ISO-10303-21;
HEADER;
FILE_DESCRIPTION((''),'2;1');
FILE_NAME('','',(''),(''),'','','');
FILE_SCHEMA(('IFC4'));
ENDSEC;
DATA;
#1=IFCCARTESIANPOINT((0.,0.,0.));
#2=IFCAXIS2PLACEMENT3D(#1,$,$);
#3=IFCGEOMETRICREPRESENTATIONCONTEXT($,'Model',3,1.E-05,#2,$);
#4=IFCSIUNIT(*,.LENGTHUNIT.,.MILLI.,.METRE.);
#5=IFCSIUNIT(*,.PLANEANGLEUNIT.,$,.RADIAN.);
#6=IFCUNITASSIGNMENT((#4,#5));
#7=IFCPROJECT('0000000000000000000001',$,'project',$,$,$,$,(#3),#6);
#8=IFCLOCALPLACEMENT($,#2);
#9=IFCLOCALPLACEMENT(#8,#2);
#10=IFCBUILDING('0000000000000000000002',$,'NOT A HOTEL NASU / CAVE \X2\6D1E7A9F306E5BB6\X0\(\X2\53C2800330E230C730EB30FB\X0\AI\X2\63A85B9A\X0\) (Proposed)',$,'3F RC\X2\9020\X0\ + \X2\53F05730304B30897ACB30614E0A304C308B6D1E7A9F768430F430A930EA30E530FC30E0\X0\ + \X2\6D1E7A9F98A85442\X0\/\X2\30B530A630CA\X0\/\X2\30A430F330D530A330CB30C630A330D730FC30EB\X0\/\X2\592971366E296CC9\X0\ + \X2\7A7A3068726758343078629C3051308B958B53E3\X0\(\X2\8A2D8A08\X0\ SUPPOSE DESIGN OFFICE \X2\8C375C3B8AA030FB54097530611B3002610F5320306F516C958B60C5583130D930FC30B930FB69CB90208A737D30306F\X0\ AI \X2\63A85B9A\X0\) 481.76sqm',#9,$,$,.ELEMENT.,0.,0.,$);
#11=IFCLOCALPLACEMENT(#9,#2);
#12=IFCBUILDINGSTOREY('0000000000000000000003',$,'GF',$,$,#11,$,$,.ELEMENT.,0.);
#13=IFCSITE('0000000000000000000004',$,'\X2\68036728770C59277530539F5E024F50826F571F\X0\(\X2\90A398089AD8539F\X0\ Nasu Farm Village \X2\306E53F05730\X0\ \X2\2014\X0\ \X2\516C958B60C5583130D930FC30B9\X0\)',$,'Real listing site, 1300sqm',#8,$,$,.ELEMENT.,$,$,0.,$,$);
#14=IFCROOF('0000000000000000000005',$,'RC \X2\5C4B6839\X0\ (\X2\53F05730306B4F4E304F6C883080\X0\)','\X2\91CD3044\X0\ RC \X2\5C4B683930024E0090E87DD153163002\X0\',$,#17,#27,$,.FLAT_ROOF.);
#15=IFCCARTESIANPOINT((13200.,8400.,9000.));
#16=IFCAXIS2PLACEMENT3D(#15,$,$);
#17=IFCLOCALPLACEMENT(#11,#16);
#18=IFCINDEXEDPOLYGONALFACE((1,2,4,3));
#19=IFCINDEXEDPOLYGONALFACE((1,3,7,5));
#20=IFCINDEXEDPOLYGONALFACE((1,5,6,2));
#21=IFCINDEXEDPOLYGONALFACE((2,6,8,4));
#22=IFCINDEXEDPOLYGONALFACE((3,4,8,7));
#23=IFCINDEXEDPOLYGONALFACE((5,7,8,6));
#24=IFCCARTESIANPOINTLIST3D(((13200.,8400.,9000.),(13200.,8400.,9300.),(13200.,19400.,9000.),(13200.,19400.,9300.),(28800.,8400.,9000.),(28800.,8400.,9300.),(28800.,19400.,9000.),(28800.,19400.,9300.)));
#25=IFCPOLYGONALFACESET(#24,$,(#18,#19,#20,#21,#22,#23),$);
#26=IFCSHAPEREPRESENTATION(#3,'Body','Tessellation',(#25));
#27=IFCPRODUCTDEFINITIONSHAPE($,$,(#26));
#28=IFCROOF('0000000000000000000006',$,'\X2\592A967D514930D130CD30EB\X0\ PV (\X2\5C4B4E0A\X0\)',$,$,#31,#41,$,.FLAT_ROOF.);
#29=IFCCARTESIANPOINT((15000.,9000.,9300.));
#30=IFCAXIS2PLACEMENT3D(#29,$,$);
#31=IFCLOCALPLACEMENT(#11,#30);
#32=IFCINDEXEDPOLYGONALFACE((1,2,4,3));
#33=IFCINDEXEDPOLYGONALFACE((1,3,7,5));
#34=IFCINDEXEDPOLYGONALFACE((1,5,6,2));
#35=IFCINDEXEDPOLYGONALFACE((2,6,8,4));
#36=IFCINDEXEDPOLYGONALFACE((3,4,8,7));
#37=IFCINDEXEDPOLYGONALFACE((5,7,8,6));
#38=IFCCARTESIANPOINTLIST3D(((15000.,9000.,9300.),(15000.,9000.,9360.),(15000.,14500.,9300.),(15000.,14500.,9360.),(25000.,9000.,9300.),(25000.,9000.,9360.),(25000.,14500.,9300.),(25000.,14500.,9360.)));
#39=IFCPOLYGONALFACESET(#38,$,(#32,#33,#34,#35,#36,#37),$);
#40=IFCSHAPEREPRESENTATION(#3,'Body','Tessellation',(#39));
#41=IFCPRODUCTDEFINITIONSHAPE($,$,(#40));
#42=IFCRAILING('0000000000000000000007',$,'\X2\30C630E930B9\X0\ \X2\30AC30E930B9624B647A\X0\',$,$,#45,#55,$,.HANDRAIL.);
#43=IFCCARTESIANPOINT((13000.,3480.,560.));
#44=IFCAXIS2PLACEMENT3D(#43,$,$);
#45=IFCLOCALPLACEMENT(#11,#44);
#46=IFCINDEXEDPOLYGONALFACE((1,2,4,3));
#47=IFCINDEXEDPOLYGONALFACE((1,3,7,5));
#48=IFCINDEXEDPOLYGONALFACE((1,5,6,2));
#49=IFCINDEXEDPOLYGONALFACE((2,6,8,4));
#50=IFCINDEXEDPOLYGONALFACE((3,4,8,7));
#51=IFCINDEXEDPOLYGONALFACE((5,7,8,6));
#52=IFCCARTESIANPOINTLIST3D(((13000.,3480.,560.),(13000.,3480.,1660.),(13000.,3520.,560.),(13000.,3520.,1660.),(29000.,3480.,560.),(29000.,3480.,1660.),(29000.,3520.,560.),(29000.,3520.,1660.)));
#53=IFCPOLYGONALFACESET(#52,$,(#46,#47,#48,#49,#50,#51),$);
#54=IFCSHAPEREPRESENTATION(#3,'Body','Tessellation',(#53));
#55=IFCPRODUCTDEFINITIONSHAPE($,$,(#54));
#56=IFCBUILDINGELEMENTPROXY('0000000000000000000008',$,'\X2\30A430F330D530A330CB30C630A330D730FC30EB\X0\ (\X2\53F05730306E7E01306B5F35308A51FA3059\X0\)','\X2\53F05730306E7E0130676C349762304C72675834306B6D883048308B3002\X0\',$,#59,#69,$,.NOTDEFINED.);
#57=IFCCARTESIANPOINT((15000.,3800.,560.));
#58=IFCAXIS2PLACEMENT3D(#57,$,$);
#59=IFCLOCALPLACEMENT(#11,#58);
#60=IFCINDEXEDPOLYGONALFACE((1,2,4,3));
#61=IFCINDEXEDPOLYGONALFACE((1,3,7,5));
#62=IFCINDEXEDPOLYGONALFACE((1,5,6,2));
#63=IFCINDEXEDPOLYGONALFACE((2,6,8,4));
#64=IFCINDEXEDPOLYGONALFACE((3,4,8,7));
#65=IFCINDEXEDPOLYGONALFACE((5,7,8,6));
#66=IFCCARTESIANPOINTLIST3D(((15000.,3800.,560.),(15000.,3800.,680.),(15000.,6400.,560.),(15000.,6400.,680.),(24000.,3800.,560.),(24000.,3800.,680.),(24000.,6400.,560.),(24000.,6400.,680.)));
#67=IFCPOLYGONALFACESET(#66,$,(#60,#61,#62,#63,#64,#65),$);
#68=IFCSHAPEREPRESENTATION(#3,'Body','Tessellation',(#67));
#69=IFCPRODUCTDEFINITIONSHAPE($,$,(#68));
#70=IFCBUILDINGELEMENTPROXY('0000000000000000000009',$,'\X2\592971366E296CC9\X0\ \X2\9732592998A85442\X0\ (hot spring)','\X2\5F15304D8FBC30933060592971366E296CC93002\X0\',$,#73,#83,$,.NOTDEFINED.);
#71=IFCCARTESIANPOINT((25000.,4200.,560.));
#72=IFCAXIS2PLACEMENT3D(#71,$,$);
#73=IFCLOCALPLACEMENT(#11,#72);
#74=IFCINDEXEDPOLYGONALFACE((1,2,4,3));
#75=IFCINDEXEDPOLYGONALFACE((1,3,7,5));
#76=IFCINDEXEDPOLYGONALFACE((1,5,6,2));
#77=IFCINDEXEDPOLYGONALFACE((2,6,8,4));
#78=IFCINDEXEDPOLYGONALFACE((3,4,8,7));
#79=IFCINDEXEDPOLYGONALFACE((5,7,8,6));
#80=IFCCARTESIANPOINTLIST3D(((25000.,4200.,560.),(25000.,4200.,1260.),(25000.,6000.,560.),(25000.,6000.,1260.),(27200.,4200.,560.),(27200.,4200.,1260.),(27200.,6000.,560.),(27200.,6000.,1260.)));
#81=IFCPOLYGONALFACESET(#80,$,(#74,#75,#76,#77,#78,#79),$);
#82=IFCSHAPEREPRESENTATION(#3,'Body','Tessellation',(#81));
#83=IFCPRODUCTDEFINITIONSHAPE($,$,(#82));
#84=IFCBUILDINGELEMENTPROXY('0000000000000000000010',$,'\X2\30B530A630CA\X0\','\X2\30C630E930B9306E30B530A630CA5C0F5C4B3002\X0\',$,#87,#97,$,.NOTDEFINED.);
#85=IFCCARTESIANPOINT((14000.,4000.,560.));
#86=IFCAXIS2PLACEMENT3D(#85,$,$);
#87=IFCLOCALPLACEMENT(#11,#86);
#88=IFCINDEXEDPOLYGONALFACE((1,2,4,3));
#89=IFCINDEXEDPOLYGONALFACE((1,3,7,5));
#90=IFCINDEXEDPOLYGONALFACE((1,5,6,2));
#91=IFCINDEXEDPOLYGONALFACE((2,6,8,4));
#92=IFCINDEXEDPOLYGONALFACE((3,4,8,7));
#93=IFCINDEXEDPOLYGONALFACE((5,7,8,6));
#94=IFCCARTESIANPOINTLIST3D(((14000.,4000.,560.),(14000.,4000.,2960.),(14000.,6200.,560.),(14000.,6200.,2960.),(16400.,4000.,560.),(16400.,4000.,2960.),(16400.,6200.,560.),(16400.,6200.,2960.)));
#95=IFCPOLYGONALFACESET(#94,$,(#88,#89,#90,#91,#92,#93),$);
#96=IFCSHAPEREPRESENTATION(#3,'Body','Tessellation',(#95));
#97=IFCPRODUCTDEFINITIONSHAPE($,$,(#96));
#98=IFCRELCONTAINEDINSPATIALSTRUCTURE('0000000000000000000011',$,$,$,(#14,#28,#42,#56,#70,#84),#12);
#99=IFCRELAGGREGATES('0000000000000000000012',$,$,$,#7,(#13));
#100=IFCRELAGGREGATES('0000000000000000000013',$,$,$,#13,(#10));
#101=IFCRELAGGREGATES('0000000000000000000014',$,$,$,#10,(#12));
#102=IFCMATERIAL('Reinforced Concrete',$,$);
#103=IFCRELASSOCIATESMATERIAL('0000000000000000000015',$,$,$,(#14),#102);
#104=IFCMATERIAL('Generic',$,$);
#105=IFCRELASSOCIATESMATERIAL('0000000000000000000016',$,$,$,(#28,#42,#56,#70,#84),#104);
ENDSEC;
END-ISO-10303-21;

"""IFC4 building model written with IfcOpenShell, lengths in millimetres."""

from ifc_helpers import new_model, si_unit, frame, frame_2d, origin, place, context, project, spatial, rectangle, extrude, material, element, save


model = new_model("IFC4")

# Units and contexts
model_context = context("Model", 3, precision=1e-05, world=origin())
ifc_project = project(units=[si_unit("LENGTHUNIT", "METRE", prefix="MILLI"), si_unit("PLANEANGLEUNIT", "RADIAN")], contexts=[model_context])

# Site, building, storey
site_placement = place(None, origin())
site = spatial("IfcSite", under=ifc_project, at=site_placement, Name="栃木県大田原市佐良土(那須高原 Nasu Farm Village の台地 — 公開情報ベース)", ObjectType="Real listing site, 1300sqm", CompositionType="ELEMENT", RefElevation=0.0)
building_placement = place(site_placement, origin())
building = spatial("IfcBuilding", under=site, at=building_placement, Name="NOT A HOTEL NASU / CAVE 洞窟の家(参考モデル・AI推定) (Proposed)", ObjectType="3F RC造 + 台地から立ち上がる洞窟的ヴォリューム + 洞窟風呂/サウナ/インフィニティプール/天然温泉 + 空と牧場へ抜ける開口(設計 SUPPOSE DESIGN OFFICE 谷尻誠・吉田愛。意匠は公開情報ベース・構造詳細は AI 推定) 481.76sqm", CompositionType="ELEMENT", ElevationOfRefHeight=0.0, ElevationOfTerrain=0.0)
storey_placement = place(building_placement, origin())
storey = spatial("IfcBuildingStorey", under=building, at=storey_placement, Name="GF", CompositionType="ELEMENT", Elevation=0.0)

# Shared definitions
ifc_material_1 = material(Name="Reinforced Concrete")

# Shared definitions
ifc_material_2 = material(Name="Generic")

# Roofs
roof_1_placement = place(storey_placement, frame((13200.0, 8400.0, 9000.0)))
element("IfcRoof", 1, at=roof_1_placement, inside=storey, material=ifc_material_1, Name="RC 屋根 (台地に低く沈む)", Description="重い RC 屋根。一部緑化。", PredefinedType="FLAT_ROOF", context=model_context, shape_type="SweptSolid", body=[
    extrude(rectangle(XDim=15600.0, YDim=11000.0, at=frame_2d((7800.0, 5500.0))), frame((13200.0, 8400.0, 9000.0)), (0.0, 0.0, 1.0), 300.0),
])
roof_2_placement = place(storey_placement, frame((15000.0, 9000.0, 9300.0)))
element("IfcRoof", 2, at=roof_2_placement, inside=storey, material=ifc_material_2, Name="太陽光パネル PV (屋上)", PredefinedType="FLAT_ROOF", context=model_context, shape_type="SweptSolid", body=[
    extrude(rectangle(XDim=10000.0, YDim=5500.0, at=frame_2d((5000.0, 2750.0))), frame((15000.0, 9000.0, 9300.0)), (0.0, 0.0, 1.0), 60.0),
])

# Railing
railing_placement = place(storey_placement, frame((13000.0, 3480.0, 560.0)))
element("IfcRailing", 3, at=railing_placement, inside=storey, material=ifc_material_2, Name="テラス ガラス手摺", PredefinedType="HANDRAIL", context=model_context, shape_type="SweptSolid", body=[
    extrude(rectangle(XDim=16000.0, YDim=40.0, at=frame_2d((8000.0, 20.0))), frame((13000.0, 3480.0, 560.0)), (0.0, 0.0, 1.0), 1100.0),
])

# Building element proxies
proxy_1_placement = place(storey_placement, frame((15000.0, 3800.0, 560.0)))
element("IfcBuildingElementProxy", 4, at=proxy_1_placement, inside=storey, material=ifc_material_2, Name="インフィニティプール (台地の縁に張り出す)", Description="台地の縁で水面が牧場に消える。", PredefinedType="NOTDEFINED", context=model_context, shape_type="SweptSolid", body=[
    extrude(rectangle(XDim=9000.0, YDim=2600.0, at=frame_2d((4500.0, 1300.0))), frame((15000.0, 3800.0, 560.0)), (0.0, 0.0, 1.0), 120.0),
])
proxy_2_placement = place(storey_placement, frame((25000.0, 4200.0, 560.0)))
element("IfcBuildingElementProxy", 5, at=proxy_2_placement, inside=storey, material=ifc_material_2, Name="天然温泉 露天風呂 (hot spring)", Description="引き込んだ天然温泉。", PredefinedType="NOTDEFINED", context=model_context, shape_type="SweptSolid", body=[
    extrude(rectangle(XDim=2200.0, YDim=1800.0, at=frame_2d((1100.0, 900.0))), frame((25000.0, 4200.0, 560.0)), (0.0, 0.0, 1.0), 700.0),
])
proxy_3_placement = place(storey_placement, frame((14000.0, 4000.0, 560.0)))
element("IfcBuildingElementProxy", 6, at=proxy_3_placement, inside=storey, material=ifc_material_2, Name="サウナ", Description="テラスのサウナ小屋。", PredefinedType="NOTDEFINED", context=model_context, shape_type="SweptSolid", body=[
    extrude(rectangle(XDim=2400.0, YDim=2200.0, at=frame_2d((1200.0, 1100.0))), frame((14000.0, 4000.0, 560.0)), (0.0, 0.0, 1.0), 2400.0),
])

save(model, "model.ifc")
